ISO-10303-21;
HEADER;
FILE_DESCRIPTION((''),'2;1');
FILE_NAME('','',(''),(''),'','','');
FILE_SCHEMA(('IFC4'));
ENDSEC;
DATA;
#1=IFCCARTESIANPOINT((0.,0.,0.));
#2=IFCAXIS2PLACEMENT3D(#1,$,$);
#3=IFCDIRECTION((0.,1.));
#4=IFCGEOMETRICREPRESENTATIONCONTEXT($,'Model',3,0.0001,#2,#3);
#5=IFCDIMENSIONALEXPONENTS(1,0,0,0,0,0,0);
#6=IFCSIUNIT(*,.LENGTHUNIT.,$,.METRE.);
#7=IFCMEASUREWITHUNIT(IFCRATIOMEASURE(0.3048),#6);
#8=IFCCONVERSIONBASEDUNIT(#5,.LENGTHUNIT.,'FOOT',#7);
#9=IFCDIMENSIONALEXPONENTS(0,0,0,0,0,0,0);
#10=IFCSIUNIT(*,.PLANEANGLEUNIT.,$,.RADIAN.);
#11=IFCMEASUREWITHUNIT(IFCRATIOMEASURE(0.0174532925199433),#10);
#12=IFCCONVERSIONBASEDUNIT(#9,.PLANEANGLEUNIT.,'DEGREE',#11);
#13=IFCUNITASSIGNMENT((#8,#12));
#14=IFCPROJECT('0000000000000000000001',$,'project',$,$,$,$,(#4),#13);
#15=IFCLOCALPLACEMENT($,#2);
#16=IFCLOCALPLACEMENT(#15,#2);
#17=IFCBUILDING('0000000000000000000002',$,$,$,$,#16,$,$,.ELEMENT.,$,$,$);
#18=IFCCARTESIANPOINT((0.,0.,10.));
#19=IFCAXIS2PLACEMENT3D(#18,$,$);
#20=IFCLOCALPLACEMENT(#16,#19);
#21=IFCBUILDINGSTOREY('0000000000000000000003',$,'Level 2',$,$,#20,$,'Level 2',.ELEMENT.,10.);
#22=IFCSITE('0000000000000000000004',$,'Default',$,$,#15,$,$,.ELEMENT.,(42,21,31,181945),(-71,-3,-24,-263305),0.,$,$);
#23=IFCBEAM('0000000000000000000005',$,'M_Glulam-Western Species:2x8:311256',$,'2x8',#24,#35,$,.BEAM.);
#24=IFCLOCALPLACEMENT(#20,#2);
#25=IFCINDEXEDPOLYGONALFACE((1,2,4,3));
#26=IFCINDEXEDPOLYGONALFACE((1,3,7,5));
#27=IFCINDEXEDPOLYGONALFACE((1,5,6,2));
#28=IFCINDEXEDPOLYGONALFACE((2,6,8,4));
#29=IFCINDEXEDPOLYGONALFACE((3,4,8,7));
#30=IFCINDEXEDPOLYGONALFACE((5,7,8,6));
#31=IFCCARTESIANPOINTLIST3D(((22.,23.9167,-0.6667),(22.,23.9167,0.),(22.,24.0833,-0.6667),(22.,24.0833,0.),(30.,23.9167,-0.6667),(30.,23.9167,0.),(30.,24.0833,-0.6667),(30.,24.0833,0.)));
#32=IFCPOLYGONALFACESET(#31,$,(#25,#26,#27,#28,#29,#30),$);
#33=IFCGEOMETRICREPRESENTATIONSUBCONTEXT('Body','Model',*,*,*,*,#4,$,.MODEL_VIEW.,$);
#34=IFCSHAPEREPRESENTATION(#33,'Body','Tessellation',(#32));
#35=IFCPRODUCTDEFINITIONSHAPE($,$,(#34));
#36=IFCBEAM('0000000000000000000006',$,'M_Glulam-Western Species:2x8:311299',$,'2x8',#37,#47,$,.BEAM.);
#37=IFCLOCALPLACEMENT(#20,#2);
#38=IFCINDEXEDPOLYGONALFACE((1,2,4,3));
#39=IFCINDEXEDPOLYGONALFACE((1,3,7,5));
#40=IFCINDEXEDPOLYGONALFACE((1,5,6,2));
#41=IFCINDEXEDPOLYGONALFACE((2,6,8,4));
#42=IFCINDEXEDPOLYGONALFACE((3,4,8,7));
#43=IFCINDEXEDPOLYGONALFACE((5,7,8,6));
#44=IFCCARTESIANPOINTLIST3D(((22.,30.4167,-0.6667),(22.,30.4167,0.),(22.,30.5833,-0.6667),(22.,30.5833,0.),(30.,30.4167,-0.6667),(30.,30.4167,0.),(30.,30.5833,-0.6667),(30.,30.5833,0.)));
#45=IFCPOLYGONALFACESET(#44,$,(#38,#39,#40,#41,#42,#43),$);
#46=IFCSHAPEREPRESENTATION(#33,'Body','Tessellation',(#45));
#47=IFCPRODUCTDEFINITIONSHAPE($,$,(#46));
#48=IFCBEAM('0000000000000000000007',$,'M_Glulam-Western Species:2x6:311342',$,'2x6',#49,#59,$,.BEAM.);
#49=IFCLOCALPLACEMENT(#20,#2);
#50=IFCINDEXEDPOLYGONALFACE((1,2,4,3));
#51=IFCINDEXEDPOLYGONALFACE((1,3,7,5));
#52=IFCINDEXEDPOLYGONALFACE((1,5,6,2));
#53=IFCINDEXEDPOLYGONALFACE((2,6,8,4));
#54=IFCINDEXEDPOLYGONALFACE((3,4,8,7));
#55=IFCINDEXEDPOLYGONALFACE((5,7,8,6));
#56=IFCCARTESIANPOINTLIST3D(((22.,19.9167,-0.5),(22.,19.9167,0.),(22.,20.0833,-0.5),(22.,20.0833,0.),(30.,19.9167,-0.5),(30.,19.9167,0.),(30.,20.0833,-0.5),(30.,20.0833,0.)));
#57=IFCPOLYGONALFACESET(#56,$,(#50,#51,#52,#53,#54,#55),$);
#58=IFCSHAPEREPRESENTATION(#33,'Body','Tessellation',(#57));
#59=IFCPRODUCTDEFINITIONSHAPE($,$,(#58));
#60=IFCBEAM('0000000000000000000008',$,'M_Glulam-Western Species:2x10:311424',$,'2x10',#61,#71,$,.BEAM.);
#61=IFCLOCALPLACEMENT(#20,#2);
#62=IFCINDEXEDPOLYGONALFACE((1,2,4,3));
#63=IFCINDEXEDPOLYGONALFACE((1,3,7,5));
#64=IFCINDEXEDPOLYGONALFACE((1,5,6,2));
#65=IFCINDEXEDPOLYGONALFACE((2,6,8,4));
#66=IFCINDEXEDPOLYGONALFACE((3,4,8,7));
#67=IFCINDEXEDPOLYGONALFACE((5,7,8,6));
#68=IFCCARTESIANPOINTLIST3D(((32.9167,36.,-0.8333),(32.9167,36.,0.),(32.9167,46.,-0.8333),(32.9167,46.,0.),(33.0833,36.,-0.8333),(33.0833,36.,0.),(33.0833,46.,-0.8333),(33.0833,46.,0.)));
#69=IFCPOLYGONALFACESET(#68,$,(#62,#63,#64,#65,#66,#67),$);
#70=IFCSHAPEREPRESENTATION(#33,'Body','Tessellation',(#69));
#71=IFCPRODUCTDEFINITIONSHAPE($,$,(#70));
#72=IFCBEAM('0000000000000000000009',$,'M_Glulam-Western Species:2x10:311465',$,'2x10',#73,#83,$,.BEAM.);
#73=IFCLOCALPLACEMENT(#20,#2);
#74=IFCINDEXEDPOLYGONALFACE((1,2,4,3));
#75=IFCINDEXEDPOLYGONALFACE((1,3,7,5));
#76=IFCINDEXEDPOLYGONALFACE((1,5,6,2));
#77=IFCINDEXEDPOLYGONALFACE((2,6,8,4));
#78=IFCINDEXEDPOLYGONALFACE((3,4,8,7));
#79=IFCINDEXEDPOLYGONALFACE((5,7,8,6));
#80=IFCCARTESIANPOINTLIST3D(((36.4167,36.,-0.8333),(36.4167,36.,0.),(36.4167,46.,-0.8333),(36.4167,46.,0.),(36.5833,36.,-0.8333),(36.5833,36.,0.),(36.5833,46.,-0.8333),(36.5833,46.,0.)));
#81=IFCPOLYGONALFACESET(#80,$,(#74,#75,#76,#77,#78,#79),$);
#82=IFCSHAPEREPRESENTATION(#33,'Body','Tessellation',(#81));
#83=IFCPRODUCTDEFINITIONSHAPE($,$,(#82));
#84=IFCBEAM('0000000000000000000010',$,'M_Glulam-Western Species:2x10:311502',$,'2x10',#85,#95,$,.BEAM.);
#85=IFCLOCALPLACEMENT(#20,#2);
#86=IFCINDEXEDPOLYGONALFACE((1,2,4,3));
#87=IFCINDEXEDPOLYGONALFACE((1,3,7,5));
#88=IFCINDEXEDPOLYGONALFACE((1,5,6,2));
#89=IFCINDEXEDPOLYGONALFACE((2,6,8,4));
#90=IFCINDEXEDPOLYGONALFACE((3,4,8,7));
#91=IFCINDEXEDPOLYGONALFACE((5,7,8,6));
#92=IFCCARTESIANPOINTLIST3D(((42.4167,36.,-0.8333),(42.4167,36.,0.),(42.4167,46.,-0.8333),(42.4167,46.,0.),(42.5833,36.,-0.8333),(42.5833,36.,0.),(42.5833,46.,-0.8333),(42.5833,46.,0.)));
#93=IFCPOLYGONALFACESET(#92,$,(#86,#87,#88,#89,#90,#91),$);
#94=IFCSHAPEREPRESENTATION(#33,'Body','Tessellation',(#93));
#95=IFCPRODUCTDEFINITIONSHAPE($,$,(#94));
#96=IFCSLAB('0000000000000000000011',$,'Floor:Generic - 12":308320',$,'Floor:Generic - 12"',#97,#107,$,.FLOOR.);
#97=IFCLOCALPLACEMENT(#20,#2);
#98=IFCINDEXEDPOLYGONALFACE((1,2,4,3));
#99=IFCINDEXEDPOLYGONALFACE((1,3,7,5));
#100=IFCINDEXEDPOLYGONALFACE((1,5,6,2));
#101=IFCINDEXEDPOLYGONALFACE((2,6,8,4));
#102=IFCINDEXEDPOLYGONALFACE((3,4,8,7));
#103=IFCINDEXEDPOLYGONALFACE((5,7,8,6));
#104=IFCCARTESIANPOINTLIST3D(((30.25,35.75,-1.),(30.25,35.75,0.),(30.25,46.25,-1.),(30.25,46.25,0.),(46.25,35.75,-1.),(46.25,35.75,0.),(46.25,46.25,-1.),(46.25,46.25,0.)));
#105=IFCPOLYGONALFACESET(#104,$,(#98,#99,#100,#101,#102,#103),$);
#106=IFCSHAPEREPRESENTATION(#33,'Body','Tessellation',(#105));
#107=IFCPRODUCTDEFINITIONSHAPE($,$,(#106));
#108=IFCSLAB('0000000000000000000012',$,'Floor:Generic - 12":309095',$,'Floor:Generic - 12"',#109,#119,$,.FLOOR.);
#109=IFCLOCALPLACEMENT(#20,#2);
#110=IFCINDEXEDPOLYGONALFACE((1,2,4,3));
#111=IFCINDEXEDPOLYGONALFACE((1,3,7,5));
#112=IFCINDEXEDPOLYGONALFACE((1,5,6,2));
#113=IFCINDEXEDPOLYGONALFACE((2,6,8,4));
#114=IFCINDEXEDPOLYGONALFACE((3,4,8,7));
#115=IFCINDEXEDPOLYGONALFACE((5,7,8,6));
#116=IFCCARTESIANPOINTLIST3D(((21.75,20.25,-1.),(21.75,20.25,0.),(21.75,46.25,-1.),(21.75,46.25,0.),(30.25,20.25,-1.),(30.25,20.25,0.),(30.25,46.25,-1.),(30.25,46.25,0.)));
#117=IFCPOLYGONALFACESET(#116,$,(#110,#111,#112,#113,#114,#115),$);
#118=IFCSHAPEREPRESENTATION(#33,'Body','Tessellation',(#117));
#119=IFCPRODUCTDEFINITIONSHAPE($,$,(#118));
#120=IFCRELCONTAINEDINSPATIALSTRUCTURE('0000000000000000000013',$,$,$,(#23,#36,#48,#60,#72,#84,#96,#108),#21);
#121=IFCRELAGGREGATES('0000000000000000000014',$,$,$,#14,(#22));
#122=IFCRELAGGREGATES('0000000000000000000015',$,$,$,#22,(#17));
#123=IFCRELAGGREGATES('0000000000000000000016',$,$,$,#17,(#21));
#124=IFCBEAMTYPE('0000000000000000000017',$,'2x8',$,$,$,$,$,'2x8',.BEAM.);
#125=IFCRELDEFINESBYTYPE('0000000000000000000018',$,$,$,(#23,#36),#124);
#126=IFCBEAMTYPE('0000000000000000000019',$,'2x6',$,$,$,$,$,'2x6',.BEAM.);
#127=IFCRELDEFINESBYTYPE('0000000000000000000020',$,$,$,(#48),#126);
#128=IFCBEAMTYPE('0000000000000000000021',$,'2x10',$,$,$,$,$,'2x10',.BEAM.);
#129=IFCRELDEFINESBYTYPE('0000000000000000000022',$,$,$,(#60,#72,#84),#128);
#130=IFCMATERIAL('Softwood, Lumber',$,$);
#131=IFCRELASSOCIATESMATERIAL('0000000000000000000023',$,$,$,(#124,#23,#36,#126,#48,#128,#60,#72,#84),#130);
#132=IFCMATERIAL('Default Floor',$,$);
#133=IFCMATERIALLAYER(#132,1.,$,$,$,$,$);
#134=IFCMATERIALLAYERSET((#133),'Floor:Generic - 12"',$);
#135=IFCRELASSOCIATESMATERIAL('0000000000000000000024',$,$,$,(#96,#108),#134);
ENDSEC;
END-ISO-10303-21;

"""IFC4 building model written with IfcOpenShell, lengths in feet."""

from ifc_helpers import new_model, entity, si_unit, converted_unit, direction, frame, frame_2d, origin, origin_2d_with_axis, place, context, subcontext, project, spatial, rectangle, extrude, source, transform, mapped, material, layer, layer_set, layer_usage, material_profile, profile_set, profile_usage, type_object, type_shapes, element, save


model = new_model("IFC4")

# Units and contexts
model_context = context("Model", 3, precision=0.0001, world=origin(), true_north=direction((0.0, 1.0)))
body_context = subcontext(model_context, "Body", "Model", "MODEL_VIEW")
ifc_project = project(units=[converted_unit("LENGTHUNIT", "FOOT", entity("IfcRatioMeasure", 0.3048), si_unit("LENGTHUNIT", "METRE"), dimensions=[1, 0, 0, 0, 0, 0, 0]), converted_unit("PLANEANGLEUNIT", "DEGREE", entity("IfcRatioMeasure", 0.0174532925199433), si_unit("PLANEANGLEUNIT", "RADIAN"), dimensions=[0, 0, 0, 0, 0, 0, 0])], contexts=[model_context])

# Site, building, storey
site_placement = place(None, origin())
site = spatial("IfcSite", under=ifc_project, at=site_placement, Name="Default", CompositionType="ELEMENT", RefLatitude=(42, 21, 31, 181945), RefLongitude=(-71, -3, -24, -263305), RefElevation=0.0)
building_placement = place(site_placement, origin())
building = spatial("IfcBuilding", under=site, at=building_placement, CompositionType="ELEMENT")
storey_placement = place(building_placement, frame((0.0, 0.0, 10.0)))
storey = spatial("IfcBuildingStorey", under=building, at=storey_placement, Name="Level 2", LongName="Level 2", CompositionType="ELEMENT", Elevation=10.0)

# Beams
ifc_material_1 = material(Name="Softwood, Lumber")
ifc_material_profile_1 = material_profile(ifc_material_1, rectangle(XDim=0.6667, YDim=0.1667, at=origin_2d_with_axis()))
ifc_profile_set_1 = profile_set([ifc_material_profile_1], Name="2x8")
ifc_profile_usage_1 = profile_usage(ifc_profile_set_1, cardinal=8)
beam_type_1 = type_object("IfcBeamType", Name="2x8", ElementType="2x8", PredefinedType="BEAM", material=ifc_profile_set_1)
shared_shape_1 = source(origin(), body_context, "Body", "SweptSolid", [
    extrude(rectangle(XDim=0.6667, YDim=0.1667, at=origin_2d_with_axis()), frame((-4.0, 0.0, 0.0), z_axis=(1.0, 0.0, 0.0), x_axis=(0.0, 0.0, -1.0)), (0.0, 0.0, 1.0), 8.0),
])
type_shapes(beam_type_1, [shared_shape_1])
beam_1_placement = place(storey_placement, frame((26.0, 24.0, -0.3333)))
element("IfcBeam", 1, at=beam_1_placement, inside=storey, type_object=beam_type_1, material=ifc_profile_usage_1, Name="M_Glulam-Western Species:2x8:311256", ObjectType="2x8", PredefinedType="BEAM", context=body_context, shape_type="MappedRepresentation", body=[
    mapped(shared_shape_1, transform((0.0, 0.0, 0.0), scale=1.0)),
])
ifc_profile_usage_2 = profile_usage(ifc_profile_set_1, cardinal=8)
beam_2_placement = place(storey_placement, frame((26.0, 30.5, -0.3333)))
element("IfcBeam", 2, at=beam_2_placement, inside=storey, type_object=beam_type_1, material=ifc_profile_usage_2, Name="M_Glulam-Western Species:2x8:311299", ObjectType="2x8", PredefinedType="BEAM", context=body_context, shape_type="MappedRepresentation", body=[
    mapped(shared_shape_1, transform((0.0, 0.0, 0.0), scale=1.0)),
])
ifc_material_profile_2 = material_profile(ifc_material_1, rectangle(XDim=0.5, YDim=0.1667, at=origin_2d_with_axis()))
ifc_profile_set_2 = profile_set([ifc_material_profile_2], Name="2x6")
ifc_profile_usage_3 = profile_usage(ifc_profile_set_2, cardinal=8)
beam_type_2 = type_object("IfcBeamType", Name="2x6", ElementType="2x6", PredefinedType="BEAM", material=ifc_profile_set_2)
shared_shape_2 = source(origin(), body_context, "Body", "SweptSolid", [
    extrude(rectangle(XDim=0.5, YDim=0.1667, at=origin_2d_with_axis()), frame((-4.0, 0.0, 0.0), z_axis=(1.0, 0.0, 0.0), x_axis=(0.0, 0.0, -1.0)), (0.0, 0.0, 1.0), 8.0),
])
type_shapes(beam_type_2, [shared_shape_2])
beam_3_placement = place(storey_placement, frame((26.0, 20.0, -0.25)))
element("IfcBeam", 3, at=beam_3_placement, inside=storey, type_object=beam_type_2, material=ifc_profile_usage_3, Name="M_Glulam-Western Species:2x6:311342", ObjectType="2x6", PredefinedType="BEAM", context=body_context, shape_type="MappedRepresentation", body=[
    mapped(shared_shape_2, transform((0.0, 0.0, 0.0), scale=1.0)),
])
ifc_material_profile_3 = material_profile(ifc_material_1, rectangle(XDim=0.8333, YDim=10.0, at=frame_2d((0.0, 0.0), x_axis=(0.0, 1.0))))
ifc_profile_set_3 = profile_set([ifc_material_profile_3], Name="2x10")
ifc_profile_usage_4 = profile_usage(ifc_profile_set_3, cardinal=8)
beam_type_3 = type_object("IfcBeamType", Name="2x10", ElementType="2x10", PredefinedType="BEAM", material=ifc_profile_set_3)
shared_shape_3 = source(origin(), body_context, "Body", "SweptSolid", [
    extrude(rectangle(XDim=0.8333, YDim=10.0, at=frame_2d((0.0, 0.0), x_axis=(0.0, 1.0))), frame((0.0, -0.0833, 0.0), z_axis=(0.0, 1.0, 0.0), x_axis=(-1.0, 0.0, 0.0)), (0.0, 0.0, 1.0), 0.1667),
])
type_shapes(beam_type_3, [shared_shape_3])
beam_4_placement = place(storey_placement, frame((33.0, 41.0, -0.4167), z_axis=(0.0, 0.0, 1.0), x_axis=(0.0, 1.0, 0.0)))
element("IfcBeam", 4, at=beam_4_placement, inside=storey, type_object=beam_type_3, material=ifc_profile_usage_4, Name="M_Glulam-Western Species:2x10:311424", ObjectType="2x10", PredefinedType="BEAM", context=body_context, shape_type="MappedRepresentation", body=[
    mapped(shared_shape_3, transform((0.0, 0.0, 0.0), scale=1.0)),
])
ifc_profile_usage_5 = profile_usage(ifc_profile_set_3, cardinal=8)
beam_5_placement = place(storey_placement, frame((36.5, 41.0, -0.4167), z_axis=(0.0, 0.0, 1.0), x_axis=(0.0, -1.0, 0.0)))
element("IfcBeam", 5, at=beam_5_placement, inside=storey, type_object=beam_type_3, material=ifc_profile_usage_5, Name="M_Glulam-Western Species:2x10:311465", ObjectType="2x10", PredefinedType="BEAM", context=body_context, shape_type="MappedRepresentation", body=[
    mapped(shared_shape_3, transform((0.0, 0.0, 0.0), scale=1.0)),
])
ifc_profile_usage_6 = profile_usage(ifc_profile_set_3, cardinal=8)
beam_6_placement = place(storey_placement, frame((42.5, 41.0, -0.4167), z_axis=(0.0, 0.0, 1.0), x_axis=(0.0, 1.0, 0.0)))
element("IfcBeam", 6, at=beam_6_placement, inside=storey, type_object=beam_type_3, material=ifc_profile_usage_6, Name="M_Glulam-Western Species:2x10:311502", ObjectType="2x10", PredefinedType="BEAM", context=body_context, shape_type="MappedRepresentation", body=[
    mapped(shared_shape_3, transform((0.0, 0.0, 0.0), scale=1.0)),
])

# Slabs
ifc_material_2 = material(Name="Default Floor")
ifc_layer = layer(ifc_material_2, 1.0)
ifc_layer_set = layer_set([ifc_layer], Name="Floor:Generic - 12\"")
ifc_layer_usage_1 = layer_usage(ifc_layer_set, "AXIS3", "POSITIVE", 0.0)
slab_1_placement = place(storey_placement, origin())
element("IfcSlab", 7, at=slab_1_placement, inside=storey, material=ifc_layer_usage_1, Name="Floor:Generic - 12\":308320", ObjectType="Floor:Generic - 12\"", PredefinedType="FLOOR", context=body_context, shape_type="SweptSolid", body=[
    extrude(rectangle(XDim=10.5, YDim=16.0, at=frame_2d((0.0, 0.0), x_axis=(1.0, 0.0))), frame((38.25, 41.0, 0.0), z_axis=(0.0, 0.0, -1.0), x_axis=(0.0, 1.0, 0.0)), (0.0, 0.0, 1.0), 1.0),
])
ifc_layer_usage_2 = layer_usage(ifc_layer_set, "AXIS3", "POSITIVE", 0.0)
slab_2_placement = place(storey_placement, origin())
element("IfcSlab", 8, at=slab_2_placement, inside=storey, material=ifc_layer_usage_2, Name="Floor:Generic - 12\":309095", ObjectType="Floor:Generic - 12\"", PredefinedType="FLOOR", context=body_context, shape_type="SweptSolid", body=[
    extrude(rectangle(XDim=26.0, YDim=8.5, at=frame_2d((0.0, 0.0), x_axis=(1.0, 0.0))), frame((26.0, 33.25, 0.0), z_axis=(0.0, 0.0, -1.0), x_axis=(0.0, 1.0, 0.0)), (0.0, 0.0, 1.0), 1.0),
])

save(model, "model.ifc")
